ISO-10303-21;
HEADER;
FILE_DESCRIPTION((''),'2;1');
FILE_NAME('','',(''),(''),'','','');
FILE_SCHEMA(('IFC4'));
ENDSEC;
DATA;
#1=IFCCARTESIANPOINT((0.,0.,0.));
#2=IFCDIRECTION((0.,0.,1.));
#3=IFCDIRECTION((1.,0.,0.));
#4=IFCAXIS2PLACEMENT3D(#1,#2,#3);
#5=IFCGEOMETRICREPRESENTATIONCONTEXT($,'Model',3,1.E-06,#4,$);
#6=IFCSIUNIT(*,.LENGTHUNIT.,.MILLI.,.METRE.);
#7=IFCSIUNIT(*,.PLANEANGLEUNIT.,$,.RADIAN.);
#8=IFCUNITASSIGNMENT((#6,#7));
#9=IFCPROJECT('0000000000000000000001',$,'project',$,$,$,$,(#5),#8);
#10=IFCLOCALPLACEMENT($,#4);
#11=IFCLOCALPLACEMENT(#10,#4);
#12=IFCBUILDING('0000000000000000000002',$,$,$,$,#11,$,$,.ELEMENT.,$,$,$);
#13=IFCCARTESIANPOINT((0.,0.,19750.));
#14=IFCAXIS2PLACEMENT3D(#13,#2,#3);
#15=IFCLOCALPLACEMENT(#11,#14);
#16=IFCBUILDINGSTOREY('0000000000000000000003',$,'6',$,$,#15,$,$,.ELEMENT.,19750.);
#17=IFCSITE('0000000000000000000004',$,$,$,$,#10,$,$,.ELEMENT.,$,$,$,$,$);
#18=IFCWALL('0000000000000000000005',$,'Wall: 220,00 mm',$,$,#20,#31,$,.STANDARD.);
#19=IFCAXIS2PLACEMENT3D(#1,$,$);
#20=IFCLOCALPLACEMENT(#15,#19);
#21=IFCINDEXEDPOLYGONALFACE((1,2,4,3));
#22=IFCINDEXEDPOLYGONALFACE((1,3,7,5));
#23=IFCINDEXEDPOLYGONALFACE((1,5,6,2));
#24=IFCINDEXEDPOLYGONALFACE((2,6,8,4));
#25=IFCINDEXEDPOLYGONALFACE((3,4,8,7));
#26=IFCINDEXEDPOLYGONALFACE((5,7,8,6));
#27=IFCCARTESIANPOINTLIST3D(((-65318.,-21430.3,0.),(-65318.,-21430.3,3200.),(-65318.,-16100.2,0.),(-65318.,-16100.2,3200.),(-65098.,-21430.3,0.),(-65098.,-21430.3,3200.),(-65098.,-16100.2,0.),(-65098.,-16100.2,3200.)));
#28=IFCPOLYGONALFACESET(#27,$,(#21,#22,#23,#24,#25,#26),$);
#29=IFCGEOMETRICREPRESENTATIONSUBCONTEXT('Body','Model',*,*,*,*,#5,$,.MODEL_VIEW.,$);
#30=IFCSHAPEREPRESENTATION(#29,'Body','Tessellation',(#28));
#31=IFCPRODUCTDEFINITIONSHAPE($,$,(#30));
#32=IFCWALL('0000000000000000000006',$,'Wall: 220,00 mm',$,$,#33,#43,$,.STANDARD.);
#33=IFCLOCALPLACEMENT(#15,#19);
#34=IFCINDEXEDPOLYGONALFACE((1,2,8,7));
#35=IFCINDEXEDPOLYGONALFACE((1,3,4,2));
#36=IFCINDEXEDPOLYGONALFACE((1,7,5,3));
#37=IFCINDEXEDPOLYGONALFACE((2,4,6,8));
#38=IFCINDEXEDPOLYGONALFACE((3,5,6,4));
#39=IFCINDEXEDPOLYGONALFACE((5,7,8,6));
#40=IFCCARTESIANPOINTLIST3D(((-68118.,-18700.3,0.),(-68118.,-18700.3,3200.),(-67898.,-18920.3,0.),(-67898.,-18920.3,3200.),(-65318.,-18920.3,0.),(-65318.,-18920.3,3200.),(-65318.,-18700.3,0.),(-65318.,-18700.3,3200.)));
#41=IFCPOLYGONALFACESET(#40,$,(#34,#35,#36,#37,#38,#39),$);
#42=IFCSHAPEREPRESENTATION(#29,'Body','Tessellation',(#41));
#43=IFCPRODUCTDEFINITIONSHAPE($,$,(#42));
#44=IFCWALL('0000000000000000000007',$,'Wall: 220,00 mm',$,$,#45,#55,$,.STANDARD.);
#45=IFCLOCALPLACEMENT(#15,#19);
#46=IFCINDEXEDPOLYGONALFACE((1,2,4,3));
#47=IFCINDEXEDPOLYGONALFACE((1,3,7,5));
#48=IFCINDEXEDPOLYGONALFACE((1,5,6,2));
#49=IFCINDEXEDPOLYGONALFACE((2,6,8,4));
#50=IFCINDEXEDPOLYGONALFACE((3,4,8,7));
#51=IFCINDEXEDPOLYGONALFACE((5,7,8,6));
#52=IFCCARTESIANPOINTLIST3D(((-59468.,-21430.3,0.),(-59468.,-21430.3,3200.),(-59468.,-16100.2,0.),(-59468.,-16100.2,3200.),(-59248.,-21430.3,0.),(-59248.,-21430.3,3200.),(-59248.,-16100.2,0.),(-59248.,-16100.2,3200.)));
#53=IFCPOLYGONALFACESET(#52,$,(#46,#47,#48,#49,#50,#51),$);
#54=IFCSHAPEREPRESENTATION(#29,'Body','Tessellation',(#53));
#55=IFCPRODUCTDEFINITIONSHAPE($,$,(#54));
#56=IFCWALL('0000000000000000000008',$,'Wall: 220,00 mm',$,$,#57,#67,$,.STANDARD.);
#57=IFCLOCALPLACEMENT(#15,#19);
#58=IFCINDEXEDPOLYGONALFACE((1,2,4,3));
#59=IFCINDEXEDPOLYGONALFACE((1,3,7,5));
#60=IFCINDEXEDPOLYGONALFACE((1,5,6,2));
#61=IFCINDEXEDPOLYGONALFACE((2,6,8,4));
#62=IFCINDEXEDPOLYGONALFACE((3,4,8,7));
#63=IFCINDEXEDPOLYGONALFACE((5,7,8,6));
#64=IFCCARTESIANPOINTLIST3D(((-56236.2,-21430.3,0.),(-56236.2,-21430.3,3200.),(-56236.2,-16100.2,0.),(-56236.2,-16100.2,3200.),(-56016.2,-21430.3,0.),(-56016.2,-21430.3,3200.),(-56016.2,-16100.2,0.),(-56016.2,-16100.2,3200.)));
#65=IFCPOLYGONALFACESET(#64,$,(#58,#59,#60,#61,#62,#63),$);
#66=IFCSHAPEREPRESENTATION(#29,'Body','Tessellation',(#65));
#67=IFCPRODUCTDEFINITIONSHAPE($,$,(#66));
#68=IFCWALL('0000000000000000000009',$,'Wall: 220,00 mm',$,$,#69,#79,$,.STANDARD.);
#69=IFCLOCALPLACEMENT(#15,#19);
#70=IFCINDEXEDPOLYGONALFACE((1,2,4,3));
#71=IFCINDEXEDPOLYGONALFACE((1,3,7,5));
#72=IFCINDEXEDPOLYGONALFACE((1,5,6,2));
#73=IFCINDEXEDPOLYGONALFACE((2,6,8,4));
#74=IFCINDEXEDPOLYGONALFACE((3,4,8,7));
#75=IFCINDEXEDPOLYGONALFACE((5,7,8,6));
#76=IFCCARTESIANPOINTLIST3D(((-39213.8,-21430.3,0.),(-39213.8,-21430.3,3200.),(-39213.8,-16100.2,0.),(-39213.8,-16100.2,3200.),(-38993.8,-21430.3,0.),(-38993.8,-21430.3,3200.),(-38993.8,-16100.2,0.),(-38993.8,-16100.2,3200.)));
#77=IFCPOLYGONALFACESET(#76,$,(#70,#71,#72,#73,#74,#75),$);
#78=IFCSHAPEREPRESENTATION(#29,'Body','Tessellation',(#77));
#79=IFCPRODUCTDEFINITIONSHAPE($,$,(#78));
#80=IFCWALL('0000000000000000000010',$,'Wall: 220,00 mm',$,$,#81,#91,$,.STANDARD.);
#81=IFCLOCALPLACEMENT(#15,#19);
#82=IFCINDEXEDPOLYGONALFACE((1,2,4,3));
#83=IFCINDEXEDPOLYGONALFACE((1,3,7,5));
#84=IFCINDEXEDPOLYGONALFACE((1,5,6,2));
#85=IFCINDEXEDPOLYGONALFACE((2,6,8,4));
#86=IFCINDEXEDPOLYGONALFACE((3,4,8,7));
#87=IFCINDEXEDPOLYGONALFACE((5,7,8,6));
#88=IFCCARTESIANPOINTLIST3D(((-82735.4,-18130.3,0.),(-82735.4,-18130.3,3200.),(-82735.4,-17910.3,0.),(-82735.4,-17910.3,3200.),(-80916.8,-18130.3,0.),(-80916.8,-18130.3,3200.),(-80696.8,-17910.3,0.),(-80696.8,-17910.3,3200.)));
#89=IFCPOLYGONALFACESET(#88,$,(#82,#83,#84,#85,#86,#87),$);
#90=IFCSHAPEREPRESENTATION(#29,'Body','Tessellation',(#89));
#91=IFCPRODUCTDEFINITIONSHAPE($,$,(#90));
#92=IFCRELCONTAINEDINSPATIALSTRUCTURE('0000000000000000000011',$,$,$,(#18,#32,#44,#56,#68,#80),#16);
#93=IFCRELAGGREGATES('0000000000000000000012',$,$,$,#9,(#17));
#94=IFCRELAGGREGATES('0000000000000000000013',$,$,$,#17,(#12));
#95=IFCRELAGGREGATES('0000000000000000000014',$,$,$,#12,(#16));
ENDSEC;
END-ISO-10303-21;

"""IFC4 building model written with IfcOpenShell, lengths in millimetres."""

from ifc_helpers import new_model, si_unit, frame, origin_with_axes, place, context, subcontext, project, spatial, line, indexed_curve, outline, extrude, element, save


model = new_model("IFC4")

# Units and contexts
model_context = context("Model", 3, precision=1e-06, world=origin_with_axes())
body_context = subcontext(model_context, "Body", "Model", "MODEL_VIEW")
ifc_project = project(units=[si_unit("LENGTHUNIT", "METRE", prefix="MILLI"), si_unit("PLANEANGLEUNIT", "RADIAN")], contexts=[model_context])

# Site, building, storey
site_placement = place(None, origin_with_axes())
site = spatial("IfcSite", under=ifc_project, at=site_placement, CompositionType="ELEMENT")
building_placement = place(site_placement, origin_with_axes())
building = spatial("IfcBuilding", under=site, at=building_placement, CompositionType="ELEMENT")
storey_placement = place(building_placement, frame((0.0, 0.0, 19750.0), z_axis=(0.0, 0.0, 1.0), x_axis=(1.0, 0.0, 0.0)))
storey = spatial("IfcBuildingStorey", under=building, at=storey_placement, Name="6", CompositionType="ELEMENT", Elevation=19750.0)

# Walls
wall_1_placement = place(storey_placement, frame((-65098.0, -16100.2, 0.0), z_axis=(0.0, 0.0, 1.0), x_axis=(0.0, -1.0, 0.0)))
element("IfcWall", 1, at=wall_1_placement, inside=storey, Name="Wall: 220,00 mm", PredefinedType="STANDARD", context=body_context, shape_type="SweptSolid", body=[
    extrude(outline(indexed_curve([(0.0, -220.0), (5330.0, -220.0), (5330.0, 0.0), (0.0, 0.0)], segments=[line(1, 2), line(2, 3), line(3, 4), line(4, 1)])), origin_with_axes(), (0.0, 0.0, 1.0), 3200.0),
])
wall_2_placement = place(storey_placement, frame((-68118.0, -18700.3, 0.0), z_axis=(0.0, 0.0, 1.0), x_axis=(1.0, 0.0, 0.0)))
element("IfcWall", 2, at=wall_2_placement, inside=storey, Name="Wall: 220,00 mm", PredefinedType="STANDARD", context=body_context, shape_type="SweptSolid", body=[
    extrude(outline(indexed_curve([(220.0, -220.0), (2800.0, -220.0), (2800.0, 0.0), (0.0, 0.0)], segments=[line(1, 2), line(2, 3), line(3, 4), line(4, 1)])), origin_with_axes(), (0.0, 0.0, 1.0), 3200.0),
])
wall_3_placement = place(storey_placement, frame((-59248.0, -16100.2, 0.0), z_axis=(0.0, 0.0, 1.0), x_axis=(0.0, -1.0, 0.0)))
element("IfcWall", 3, at=wall_3_placement, inside=storey, Name="Wall: 220,00 mm", PredefinedType="STANDARD", context=body_context, shape_type="SweptSolid", body=[
    extrude(outline(indexed_curve([(0.0, -220.0), (5330.0, -220.0), (5330.0, 0.0), (0.0, 0.0)], segments=[line(1, 2), line(2, 3), line(3, 4), line(4, 1)])), origin_with_axes(), (0.0, 0.0, 1.0), 3200.0),
])
wall_4_placement = place(storey_placement, frame((-56016.2, -21430.3, 0.0), z_axis=(0.0, 0.0, 1.0), x_axis=(0.0, 1.0, 0.0)))
element("IfcWall", 4, at=wall_4_placement, inside=storey, Name="Wall: 220,00 mm", PredefinedType="STANDARD", context=body_context, shape_type="SweptSolid", body=[
    extrude(outline(indexed_curve([(0.0, 0.0), (5330.0, 0.0), (5330.0, 220.0), (0.0, 220.0)], segments=[line(1, 2), line(2, 3), line(3, 4), line(4, 1)])), origin_with_axes(), (0.0, 0.0, 1.0), 3200.0),
])
wall_5_placement = place(storey_placement, frame((-38993.8, -16100.2, 0.0), z_axis=(0.0, 0.0, 1.0), x_axis=(0.0, -1.0, 0.0)))
element("IfcWall", 5, at=wall_5_placement, inside=storey, Name="Wall: 220,00 mm", PredefinedType="STANDARD", context=body_context, shape_type="SweptSolid", body=[
    extrude(outline(indexed_curve([(0.0, -220.0), (5330.0, -220.0), (5330.0, 0.0), (0.0, 0.0)], segments=[line(1, 2), line(2, 3), line(3, 4), line(4, 1)])), origin_with_axes(), (0.0, 0.0, 1.0), 3200.0),
])
wall_6_placement = place(storey_placement, frame((-80916.8, -18130.3, 0.0), z_axis=(0.0, 0.0, 1.0), x_axis=(-1.0, 0.0, 0.0)))
element("IfcWall", 6, at=wall_6_placement, inside=storey, Name="Wall: 220,00 mm", PredefinedType="STANDARD", context=body_context, shape_type="SweptSolid", body=[
    extrude(outline(indexed_curve([(-220.0, -220.0), (1818.6, -220.0), (1818.6, 0.0), (0.0, 0.0)], segments=[line(1, 2), line(2, 3), line(3, 4), line(4, 1)])), origin_with_axes(), (0.0, 0.0, 1.0), 3200.0),
])

save(model, "model.ifc")
